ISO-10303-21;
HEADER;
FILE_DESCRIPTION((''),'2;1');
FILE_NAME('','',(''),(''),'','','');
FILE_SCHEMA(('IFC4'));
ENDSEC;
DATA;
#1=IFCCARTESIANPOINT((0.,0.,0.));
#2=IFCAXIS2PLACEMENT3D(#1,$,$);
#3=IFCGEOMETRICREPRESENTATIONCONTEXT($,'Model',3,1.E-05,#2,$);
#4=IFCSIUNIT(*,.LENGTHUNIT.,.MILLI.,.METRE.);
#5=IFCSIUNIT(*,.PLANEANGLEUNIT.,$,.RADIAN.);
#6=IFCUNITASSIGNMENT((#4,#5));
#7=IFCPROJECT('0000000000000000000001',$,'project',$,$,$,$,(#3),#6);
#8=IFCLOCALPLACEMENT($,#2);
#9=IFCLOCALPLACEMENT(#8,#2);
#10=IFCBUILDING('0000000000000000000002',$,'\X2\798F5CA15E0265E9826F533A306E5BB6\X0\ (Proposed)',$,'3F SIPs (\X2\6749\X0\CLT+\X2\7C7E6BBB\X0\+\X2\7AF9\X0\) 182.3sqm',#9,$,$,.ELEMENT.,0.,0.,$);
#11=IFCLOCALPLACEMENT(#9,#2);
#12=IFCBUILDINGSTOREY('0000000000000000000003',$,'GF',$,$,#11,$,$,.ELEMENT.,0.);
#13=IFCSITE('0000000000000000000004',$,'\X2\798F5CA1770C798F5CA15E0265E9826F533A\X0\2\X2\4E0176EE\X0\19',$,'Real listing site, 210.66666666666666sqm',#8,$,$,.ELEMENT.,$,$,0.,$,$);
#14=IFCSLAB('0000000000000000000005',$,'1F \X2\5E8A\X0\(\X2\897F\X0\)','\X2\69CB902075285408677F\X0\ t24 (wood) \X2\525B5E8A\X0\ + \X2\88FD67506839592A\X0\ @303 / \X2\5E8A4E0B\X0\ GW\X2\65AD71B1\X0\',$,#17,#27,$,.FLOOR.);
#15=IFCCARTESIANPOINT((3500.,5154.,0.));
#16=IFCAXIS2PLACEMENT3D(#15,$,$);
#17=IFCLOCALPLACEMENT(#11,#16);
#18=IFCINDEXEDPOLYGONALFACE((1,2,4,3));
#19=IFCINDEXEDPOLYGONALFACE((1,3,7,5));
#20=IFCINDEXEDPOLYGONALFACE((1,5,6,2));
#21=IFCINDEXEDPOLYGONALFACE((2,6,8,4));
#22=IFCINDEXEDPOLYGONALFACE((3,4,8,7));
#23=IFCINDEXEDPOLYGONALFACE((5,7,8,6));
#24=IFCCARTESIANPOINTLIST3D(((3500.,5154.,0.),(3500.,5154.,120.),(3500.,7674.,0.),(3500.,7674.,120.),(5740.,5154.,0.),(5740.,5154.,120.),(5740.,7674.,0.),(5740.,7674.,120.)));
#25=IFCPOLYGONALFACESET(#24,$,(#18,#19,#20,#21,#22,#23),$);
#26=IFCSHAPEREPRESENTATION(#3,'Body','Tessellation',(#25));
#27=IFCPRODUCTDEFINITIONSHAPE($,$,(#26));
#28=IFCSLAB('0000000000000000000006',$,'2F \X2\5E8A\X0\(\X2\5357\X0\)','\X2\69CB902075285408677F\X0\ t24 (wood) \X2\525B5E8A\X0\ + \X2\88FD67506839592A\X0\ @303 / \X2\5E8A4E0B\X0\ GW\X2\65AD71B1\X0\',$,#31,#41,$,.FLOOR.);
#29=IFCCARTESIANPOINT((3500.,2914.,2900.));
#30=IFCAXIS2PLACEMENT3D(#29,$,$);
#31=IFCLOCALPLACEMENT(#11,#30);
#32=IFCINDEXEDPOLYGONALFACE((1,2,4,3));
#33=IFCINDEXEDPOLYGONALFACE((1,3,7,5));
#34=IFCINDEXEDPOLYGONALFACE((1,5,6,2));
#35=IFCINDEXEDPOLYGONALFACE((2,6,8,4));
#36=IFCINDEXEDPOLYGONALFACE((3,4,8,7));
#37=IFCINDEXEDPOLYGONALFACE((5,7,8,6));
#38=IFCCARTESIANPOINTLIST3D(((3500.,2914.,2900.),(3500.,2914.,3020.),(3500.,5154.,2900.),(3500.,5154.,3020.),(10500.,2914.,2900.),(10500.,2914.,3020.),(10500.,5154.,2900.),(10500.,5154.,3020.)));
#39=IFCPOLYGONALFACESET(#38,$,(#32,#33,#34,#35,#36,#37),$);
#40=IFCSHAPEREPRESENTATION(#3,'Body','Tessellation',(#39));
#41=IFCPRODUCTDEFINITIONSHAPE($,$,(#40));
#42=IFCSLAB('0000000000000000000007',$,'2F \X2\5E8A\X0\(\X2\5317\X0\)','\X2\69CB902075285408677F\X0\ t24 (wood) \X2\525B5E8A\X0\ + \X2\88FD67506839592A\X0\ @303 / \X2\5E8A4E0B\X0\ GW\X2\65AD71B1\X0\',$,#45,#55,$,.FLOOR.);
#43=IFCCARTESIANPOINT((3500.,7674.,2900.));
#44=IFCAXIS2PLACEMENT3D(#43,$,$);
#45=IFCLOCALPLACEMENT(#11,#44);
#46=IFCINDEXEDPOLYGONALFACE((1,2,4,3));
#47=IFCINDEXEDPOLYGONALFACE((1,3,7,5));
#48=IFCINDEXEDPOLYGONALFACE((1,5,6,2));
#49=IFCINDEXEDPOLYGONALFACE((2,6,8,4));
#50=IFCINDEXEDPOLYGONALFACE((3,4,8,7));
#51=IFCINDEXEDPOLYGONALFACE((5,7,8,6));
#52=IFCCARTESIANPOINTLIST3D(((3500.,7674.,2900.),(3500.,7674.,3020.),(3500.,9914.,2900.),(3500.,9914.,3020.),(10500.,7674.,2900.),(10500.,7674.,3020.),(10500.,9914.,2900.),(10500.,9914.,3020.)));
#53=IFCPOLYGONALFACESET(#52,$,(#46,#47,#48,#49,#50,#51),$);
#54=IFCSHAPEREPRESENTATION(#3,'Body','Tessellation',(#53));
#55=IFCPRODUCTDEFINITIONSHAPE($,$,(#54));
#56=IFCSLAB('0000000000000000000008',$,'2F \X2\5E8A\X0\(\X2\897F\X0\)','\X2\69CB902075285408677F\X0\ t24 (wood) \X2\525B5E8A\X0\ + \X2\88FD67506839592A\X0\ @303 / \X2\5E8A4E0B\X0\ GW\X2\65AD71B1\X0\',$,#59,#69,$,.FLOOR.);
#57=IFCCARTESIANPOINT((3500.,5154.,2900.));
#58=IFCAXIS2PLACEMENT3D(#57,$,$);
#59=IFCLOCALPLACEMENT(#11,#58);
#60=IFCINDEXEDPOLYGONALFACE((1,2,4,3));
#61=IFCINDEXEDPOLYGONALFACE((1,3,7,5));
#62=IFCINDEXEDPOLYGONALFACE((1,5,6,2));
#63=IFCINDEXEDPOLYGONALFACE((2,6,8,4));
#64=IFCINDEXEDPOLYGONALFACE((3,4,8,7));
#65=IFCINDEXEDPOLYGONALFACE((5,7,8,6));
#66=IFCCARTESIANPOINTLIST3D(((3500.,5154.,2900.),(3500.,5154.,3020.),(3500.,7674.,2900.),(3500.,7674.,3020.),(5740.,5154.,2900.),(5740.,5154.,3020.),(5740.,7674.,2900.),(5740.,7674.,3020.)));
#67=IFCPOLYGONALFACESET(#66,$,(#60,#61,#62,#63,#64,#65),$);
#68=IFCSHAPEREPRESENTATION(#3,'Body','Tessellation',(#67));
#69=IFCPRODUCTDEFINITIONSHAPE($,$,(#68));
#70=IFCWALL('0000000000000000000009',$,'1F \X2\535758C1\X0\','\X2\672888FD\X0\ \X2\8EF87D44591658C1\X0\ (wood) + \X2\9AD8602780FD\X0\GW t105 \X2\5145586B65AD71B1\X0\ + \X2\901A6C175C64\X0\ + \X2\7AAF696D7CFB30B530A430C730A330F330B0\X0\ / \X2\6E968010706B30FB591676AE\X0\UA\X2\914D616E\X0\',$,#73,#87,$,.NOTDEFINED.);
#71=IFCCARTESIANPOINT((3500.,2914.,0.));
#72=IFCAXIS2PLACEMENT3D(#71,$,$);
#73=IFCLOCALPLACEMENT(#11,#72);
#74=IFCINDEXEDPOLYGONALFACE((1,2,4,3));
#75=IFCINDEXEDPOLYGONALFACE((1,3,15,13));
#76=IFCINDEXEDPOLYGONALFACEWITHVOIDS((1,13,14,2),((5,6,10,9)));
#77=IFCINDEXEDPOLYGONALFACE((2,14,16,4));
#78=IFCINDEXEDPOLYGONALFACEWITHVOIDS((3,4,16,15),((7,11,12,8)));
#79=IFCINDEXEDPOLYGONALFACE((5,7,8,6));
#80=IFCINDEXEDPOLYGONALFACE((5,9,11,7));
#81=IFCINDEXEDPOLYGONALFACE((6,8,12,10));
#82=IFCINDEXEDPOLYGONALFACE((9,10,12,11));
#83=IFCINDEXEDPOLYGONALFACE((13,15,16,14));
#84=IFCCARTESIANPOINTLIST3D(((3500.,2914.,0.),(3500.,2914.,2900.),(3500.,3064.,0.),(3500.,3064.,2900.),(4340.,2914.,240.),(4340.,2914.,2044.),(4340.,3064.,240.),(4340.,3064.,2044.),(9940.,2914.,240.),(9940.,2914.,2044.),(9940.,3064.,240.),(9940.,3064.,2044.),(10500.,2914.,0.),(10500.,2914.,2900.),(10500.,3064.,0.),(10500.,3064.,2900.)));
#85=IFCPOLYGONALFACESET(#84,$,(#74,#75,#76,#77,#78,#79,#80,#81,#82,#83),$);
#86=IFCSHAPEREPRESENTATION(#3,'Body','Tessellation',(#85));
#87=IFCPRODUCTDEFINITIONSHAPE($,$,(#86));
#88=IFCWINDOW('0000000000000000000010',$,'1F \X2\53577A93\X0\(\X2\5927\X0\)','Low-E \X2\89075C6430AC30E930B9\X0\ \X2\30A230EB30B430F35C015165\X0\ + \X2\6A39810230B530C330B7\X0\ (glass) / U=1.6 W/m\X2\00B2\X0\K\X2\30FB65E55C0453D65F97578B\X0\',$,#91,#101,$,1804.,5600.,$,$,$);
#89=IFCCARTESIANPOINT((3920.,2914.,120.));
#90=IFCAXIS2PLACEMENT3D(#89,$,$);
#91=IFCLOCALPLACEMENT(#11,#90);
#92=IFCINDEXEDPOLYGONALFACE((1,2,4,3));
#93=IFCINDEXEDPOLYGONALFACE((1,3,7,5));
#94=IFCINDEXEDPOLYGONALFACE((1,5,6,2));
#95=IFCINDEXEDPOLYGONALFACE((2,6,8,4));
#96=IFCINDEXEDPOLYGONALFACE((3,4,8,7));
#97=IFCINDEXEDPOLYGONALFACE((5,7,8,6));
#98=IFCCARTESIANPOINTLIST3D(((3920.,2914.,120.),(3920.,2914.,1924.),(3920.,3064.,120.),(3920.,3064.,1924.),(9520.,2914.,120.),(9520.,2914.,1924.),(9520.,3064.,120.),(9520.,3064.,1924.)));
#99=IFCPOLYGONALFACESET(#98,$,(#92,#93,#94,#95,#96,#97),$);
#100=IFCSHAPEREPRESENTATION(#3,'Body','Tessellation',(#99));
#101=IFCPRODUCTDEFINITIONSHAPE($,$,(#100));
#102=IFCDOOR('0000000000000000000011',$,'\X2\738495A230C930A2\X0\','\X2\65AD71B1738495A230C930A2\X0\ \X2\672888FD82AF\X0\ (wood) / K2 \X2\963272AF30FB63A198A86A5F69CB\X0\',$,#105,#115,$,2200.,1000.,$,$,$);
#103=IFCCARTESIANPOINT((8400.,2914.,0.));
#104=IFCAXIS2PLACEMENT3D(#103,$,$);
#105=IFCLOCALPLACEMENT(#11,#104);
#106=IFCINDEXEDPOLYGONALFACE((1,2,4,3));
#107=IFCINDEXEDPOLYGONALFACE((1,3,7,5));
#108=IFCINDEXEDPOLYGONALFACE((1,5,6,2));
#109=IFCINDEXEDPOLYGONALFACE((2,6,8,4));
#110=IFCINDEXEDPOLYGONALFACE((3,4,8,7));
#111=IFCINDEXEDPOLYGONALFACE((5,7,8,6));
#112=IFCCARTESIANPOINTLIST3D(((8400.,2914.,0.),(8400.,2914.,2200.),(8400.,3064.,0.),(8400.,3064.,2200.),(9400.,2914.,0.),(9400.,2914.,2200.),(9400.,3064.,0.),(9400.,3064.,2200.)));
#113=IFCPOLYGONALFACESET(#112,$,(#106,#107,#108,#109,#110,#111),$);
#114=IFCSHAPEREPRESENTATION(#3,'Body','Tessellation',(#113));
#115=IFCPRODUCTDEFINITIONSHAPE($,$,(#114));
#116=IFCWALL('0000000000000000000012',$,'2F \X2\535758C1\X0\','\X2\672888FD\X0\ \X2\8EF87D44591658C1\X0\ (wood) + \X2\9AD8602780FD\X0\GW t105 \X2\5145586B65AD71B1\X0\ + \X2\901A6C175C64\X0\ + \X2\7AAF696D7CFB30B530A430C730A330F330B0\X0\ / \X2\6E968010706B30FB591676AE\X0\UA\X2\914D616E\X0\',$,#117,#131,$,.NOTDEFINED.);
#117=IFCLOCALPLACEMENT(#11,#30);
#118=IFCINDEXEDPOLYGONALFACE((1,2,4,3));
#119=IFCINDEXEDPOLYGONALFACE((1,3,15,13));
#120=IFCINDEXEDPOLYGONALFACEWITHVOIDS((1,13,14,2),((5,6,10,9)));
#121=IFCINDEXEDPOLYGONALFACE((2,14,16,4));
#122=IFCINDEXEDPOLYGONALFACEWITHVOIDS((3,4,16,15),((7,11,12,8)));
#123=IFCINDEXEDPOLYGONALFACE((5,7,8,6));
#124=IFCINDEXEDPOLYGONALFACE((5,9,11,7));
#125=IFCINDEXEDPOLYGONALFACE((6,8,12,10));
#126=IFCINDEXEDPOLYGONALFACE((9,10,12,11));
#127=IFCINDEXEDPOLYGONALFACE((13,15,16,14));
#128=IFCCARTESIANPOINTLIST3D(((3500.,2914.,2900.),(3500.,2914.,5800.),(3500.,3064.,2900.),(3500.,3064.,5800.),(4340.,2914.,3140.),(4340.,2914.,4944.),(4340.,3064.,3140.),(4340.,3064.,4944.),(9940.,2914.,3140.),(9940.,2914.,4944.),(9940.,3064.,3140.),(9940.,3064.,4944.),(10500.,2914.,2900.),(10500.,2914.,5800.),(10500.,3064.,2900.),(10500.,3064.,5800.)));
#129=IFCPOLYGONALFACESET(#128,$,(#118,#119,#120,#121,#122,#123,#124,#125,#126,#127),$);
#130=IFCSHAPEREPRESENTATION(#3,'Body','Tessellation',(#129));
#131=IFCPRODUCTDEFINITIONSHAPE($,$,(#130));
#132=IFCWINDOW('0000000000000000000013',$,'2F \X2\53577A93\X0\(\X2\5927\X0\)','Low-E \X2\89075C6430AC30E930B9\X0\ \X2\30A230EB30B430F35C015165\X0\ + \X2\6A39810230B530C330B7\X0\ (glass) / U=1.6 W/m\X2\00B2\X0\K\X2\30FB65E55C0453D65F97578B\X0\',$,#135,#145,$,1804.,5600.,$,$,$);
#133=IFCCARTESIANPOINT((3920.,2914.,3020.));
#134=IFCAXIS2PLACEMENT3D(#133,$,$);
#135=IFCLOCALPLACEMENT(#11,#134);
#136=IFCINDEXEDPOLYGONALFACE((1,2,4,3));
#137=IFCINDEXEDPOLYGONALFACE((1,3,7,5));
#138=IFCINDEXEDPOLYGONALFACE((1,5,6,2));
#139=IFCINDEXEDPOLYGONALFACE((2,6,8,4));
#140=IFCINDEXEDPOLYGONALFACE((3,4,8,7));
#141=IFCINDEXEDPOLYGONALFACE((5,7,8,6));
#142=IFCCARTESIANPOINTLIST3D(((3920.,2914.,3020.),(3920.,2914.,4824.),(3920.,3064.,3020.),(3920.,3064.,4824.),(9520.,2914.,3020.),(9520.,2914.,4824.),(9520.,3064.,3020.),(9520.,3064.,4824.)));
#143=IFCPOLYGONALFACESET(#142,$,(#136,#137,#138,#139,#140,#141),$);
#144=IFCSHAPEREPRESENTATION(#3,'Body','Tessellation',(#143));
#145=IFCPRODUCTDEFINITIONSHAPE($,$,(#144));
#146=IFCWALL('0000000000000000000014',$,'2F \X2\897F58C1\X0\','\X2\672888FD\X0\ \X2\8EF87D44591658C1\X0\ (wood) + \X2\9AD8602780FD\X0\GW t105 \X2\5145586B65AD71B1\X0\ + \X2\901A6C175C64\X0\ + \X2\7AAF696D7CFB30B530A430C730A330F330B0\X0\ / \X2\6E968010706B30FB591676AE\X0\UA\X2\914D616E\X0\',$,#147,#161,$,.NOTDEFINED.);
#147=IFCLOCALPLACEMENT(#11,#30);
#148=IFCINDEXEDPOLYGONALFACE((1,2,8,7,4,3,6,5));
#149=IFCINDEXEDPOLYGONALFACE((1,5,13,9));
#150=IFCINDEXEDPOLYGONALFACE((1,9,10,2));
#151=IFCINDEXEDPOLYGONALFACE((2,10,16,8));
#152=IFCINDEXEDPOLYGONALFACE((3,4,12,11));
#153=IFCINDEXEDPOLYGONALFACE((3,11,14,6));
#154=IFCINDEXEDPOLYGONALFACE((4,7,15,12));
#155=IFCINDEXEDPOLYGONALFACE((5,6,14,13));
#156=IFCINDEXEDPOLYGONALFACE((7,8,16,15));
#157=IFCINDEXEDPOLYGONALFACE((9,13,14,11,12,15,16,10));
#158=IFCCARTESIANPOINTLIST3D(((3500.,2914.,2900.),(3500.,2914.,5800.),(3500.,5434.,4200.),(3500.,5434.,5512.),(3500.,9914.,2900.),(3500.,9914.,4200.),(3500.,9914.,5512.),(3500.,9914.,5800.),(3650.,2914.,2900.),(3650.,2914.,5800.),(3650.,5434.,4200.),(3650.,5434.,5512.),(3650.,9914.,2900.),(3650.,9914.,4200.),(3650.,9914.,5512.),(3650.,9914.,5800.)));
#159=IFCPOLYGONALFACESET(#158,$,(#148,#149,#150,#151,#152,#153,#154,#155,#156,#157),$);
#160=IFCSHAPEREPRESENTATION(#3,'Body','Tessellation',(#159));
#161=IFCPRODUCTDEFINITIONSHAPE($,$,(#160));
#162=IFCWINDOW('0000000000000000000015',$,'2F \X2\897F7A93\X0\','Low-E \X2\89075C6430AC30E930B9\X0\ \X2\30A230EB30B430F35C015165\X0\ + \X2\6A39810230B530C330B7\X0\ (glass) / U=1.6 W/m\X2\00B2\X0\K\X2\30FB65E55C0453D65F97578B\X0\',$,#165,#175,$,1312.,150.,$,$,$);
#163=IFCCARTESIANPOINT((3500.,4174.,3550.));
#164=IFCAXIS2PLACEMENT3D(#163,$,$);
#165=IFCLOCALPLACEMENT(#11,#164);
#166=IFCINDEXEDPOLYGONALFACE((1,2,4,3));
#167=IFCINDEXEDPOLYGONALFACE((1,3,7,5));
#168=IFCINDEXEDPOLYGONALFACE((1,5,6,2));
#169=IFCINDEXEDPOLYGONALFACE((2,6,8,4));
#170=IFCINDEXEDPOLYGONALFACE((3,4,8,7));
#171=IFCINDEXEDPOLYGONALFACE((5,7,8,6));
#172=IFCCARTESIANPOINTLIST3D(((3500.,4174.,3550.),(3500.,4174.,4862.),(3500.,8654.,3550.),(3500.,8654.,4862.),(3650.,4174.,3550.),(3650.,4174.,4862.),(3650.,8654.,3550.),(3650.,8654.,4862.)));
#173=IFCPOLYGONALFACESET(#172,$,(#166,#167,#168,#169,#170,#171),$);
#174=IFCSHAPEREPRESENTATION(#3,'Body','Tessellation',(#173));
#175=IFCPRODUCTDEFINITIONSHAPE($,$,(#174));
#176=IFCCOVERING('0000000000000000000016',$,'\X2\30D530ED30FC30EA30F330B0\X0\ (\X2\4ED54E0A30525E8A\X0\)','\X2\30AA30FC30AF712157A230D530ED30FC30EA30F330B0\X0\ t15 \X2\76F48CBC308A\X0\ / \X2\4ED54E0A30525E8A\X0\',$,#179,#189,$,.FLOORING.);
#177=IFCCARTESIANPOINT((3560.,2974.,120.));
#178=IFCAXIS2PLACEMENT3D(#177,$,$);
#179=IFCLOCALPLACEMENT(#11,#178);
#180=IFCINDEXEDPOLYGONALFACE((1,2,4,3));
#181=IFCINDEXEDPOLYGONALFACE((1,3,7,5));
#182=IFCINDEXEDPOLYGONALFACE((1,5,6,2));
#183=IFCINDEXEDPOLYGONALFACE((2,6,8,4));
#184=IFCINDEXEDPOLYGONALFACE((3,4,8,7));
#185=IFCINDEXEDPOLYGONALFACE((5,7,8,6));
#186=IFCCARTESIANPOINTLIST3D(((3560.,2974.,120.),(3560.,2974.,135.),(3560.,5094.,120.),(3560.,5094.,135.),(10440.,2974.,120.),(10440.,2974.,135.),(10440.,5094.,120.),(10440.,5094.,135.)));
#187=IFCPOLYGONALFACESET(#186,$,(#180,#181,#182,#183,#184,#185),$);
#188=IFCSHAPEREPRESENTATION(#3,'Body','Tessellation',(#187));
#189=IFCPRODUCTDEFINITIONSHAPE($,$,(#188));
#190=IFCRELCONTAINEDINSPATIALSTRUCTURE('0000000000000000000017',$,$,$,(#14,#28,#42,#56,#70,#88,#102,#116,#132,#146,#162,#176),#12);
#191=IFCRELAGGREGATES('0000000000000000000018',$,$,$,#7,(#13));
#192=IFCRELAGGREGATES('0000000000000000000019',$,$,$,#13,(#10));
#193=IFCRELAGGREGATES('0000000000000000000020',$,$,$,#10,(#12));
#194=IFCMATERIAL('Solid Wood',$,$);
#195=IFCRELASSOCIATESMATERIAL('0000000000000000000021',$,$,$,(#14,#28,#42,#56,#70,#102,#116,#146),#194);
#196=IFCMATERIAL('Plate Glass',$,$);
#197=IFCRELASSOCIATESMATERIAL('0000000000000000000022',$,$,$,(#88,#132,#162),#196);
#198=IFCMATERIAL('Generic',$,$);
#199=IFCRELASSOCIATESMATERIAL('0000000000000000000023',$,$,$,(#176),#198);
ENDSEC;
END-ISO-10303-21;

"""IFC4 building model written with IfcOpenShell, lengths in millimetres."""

from ifc_helpers import new_model, si_unit, frame, frame_2d, origin, place, context, project, spatial, rectangle, extrude, material, element, fill, save


model = new_model("IFC4")

# Units and contexts
model_context = context("Model", 3, precision=1e-05, world=origin())
ifc_project = project(units=[si_unit("LENGTHUNIT", "METRE", prefix="MILLI"), si_unit("PLANEANGLEUNIT", "RADIAN")], contexts=[model_context])

# Site, building, storey
site_placement = place(None, origin())
site = spatial("IfcSite", under=ifc_project, at=site_placement, Name="福岡県福岡市早良区2丁目19", ObjectType="Real listing site, 210.66666666666666sqm", CompositionType="ELEMENT", RefElevation=0.0)
building_placement = place(site_placement, origin())
building = spatial("IfcBuilding", under=site, at=building_placement, Name="福岡市早良区の家 (Proposed)", ObjectType="3F SIPs (杉CLT+籾殻+竹) 182.3sqm", CompositionType="ELEMENT", ElevationOfRefHeight=0.0, ElevationOfTerrain=0.0)
storey_placement = place(building_placement, origin())
storey = spatial("IfcBuildingStorey", under=building, at=storey_placement, Name="GF", CompositionType="ELEMENT", Elevation=0.0)

# Slabs
ifc_material_1 = material(Name="Solid Wood")
slab_1_placement = place(storey_placement, frame((3500.0, 5154.0, 0.0)))
element("IfcSlab", 1, at=slab_1_placement, inside=storey, material=ifc_material_1, Name="1F 床(西)", Description="構造用合板 t24 (wood) 剛床 + 製材根太 @303 / 床下 GW断熱", PredefinedType="FLOOR", context=model_context, shape_type="SweptSolid", body=[
    extrude(rectangle(XDim=2240.0, YDim=2520.0, at=frame_2d((1120.0, 1260.0))), frame((3500.0, 5154.0, 0.0)), (0.0, 0.0, 1.0), 120.0),
])
slab_2_placement = place(storey_placement, frame((3500.0, 2914.0, 2900.0)))
element("IfcSlab", 2, at=slab_2_placement, inside=storey, material=ifc_material_1, Name="2F 床(南)", Description="構造用合板 t24 (wood) 剛床 + 製材根太 @303 / 床下 GW断熱", PredefinedType="FLOOR", context=model_context, shape_type="SweptSolid", body=[
    extrude(rectangle(XDim=7000.0, YDim=2240.0, at=frame_2d((3500.0, 1120.0))), frame((3500.0, 2914.0, 2900.0)), (0.0, 0.0, 1.0), 120.0),
])
slab_3_placement = place(storey_placement, frame((3500.0, 7674.0, 2900.0)))
element("IfcSlab", 3, at=slab_3_placement, inside=storey, material=ifc_material_1, Name="2F 床(北)", Description="構造用合板 t24 (wood) 剛床 + 製材根太 @303 / 床下 GW断熱", PredefinedType="FLOOR", context=model_context, shape_type="SweptSolid", body=[
    extrude(rectangle(XDim=7000.0, YDim=2240.0, at=frame_2d((3500.0, 1120.0))), frame((3500.0, 7674.0, 2900.0)), (0.0, 0.0, 1.0), 120.0),
])
slab_4_placement = place(storey_placement, frame((3500.0, 5154.0, 2900.0)))
element("IfcSlab", 4, at=slab_4_placement, inside=storey, material=ifc_material_1, Name="2F 床(西)", Description="構造用合板 t24 (wood) 剛床 + 製材根太 @303 / 床下 GW断熱", PredefinedType="FLOOR", context=model_context, shape_type="SweptSolid", body=[
    extrude(rectangle(XDim=2240.0, YDim=2520.0, at=frame_2d((1120.0, 1260.0))), frame((3500.0, 5154.0, 2900.0)), (0.0, 0.0, 1.0), 120.0),
])

# Wall, openings, window, door
wall_1_placement = place(storey_placement, frame((3500.0, 2914.0, 0.0)))
wall_1 = element("IfcWall", 5, at=wall_1_placement, inside=storey, material=ifc_material_1, Name="1F 南壁", Description="木製 軸組外壁 (wood) + 高性能GW t105 充填断熱 + 通気層 + 窯業系サイディング / 準耐火・外皮UA配慮", PredefinedType="NOTDEFINED", context=model_context, shape_type="SweptSolid", body=[
    extrude(rectangle(XDim=7000.0, YDim=150.0, at=frame_2d((3500.0, 75.0))), frame((3500.0, 2914.0, 0.0)), (0.0, 0.0, 1.0), 2900.0),
])
opening_1_placement = place(storey_placement, frame((3920.0, 2914.0, 120.0)))
opening_1 = element("IfcOpeningElement", 6, at=opening_1_placement, cuts=wall_1, PredefinedType="NOTDEFINED", context=model_context, shape_type="SweptSolid", body=[
    extrude(rectangle(XDim=5600.0, YDim=150.0, at=frame_2d((2800.0, 75.0))), frame((3920.0, 2914.0, 120.0)), (0.0, 0.0, 1.0), 1804.0),
])
opening_2_placement = place(storey_placement, frame((8400.0, 2914.0, 0.0)))
opening_2 = element("IfcOpeningElement", 7, at=opening_2_placement, cuts=wall_1, PredefinedType="NOTDEFINED", context=model_context, shape_type="SweptSolid", body=[
    extrude(rectangle(XDim=1000.0, YDim=150.0, at=frame_2d((500.0, 75.0))), frame((8400.0, 2914.0, 0.0)), (0.0, 0.0, 1.0), 2200.0),
])
ifc_material_2 = material(Name="Plate Glass")
window_1_placement = place(storey_placement, frame((3920.0, 2914.0, 120.0)))
window_1 = element("IfcWindow", 8, at=window_1_placement, inside=storey, material=ifc_material_2, Name="1F 南窓(大)", Description="Low-E 複層ガラス アルゴン封入 + 樹脂サッシ (glass) / U=1.6 W/m²K・日射取得型", OverallHeight=1804.0, OverallWidth=5600.0, context=model_context, shape_type="SweptSolid", body=[
    extrude(rectangle(XDim=5600.0, YDim=150.0, at=frame_2d((2800.0, 75.0))), frame((3920.0, 2914.0, 120.0)), (0.0, 0.0, 1.0), 1804.0),
])
fill(opening_1, window_1)
door_placement = place(storey_placement, frame((8400.0, 2914.0, 0.0)))
door = element("IfcDoor", 9, at=door_placement, inside=storey, material=ifc_material_1, Name="玄関ドア", Description="断熱玄関ドア 木製芯 (wood) / K2 防犯・採風機構", OverallHeight=2200.0, OverallWidth=1000.0, context=model_context, shape_type="SweptSolid", body=[
    extrude(rectangle(XDim=1000.0, YDim=150.0, at=frame_2d((500.0, 75.0))), frame((8400.0, 2914.0, 0.0)), (0.0, 0.0, 1.0), 2200.0),
])
fill(opening_2, door)

# Wall, opening, window
wall_2_placement = place(storey_placement, frame((3500.0, 2914.0, 2900.0)))
wall_2 = element("IfcWall", 10, at=wall_2_placement, inside=storey, material=ifc_material_1, Name="2F 南壁", Description="木製 軸組外壁 (wood) + 高性能GW t105 充填断熱 + 通気層 + 窯業系サイディング / 準耐火・外皮UA配慮", PredefinedType="NOTDEFINED", context=model_context, shape_type="SweptSolid", body=[
    extrude(rectangle(XDim=7000.0, YDim=150.0, at=frame_2d((3500.0, 75.0))), frame((3500.0, 2914.0, 2900.0)), (0.0, 0.0, 1.0), 2900.0),
])
opening_3_placement = place(storey_placement, frame((3920.0, 2914.0, 3020.0)))
opening_3 = element("IfcOpeningElement", 11, at=opening_3_placement, cuts=wall_2, PredefinedType="NOTDEFINED", context=model_context, shape_type="SweptSolid", body=[
    extrude(rectangle(XDim=5600.0, YDim=150.0, at=frame_2d((2800.0, 75.0))), frame((3920.0, 2914.0, 3020.0)), (0.0, 0.0, 1.0), 1804.0),
])
window_2_placement = place(storey_placement, frame((3920.0, 2914.0, 3020.0)))
window_2 = element("IfcWindow", 12, at=window_2_placement, inside=storey, material=ifc_material_2, Name="2F 南窓(大)", Description="Low-E 複層ガラス アルゴン封入 + 樹脂サッシ (glass) / U=1.6 W/m²K・日射取得型", OverallHeight=1804.0, OverallWidth=5600.0, context=model_context, shape_type="SweptSolid", body=[
    extrude(rectangle(XDim=5600.0, YDim=150.0, at=frame_2d((2800.0, 75.0))), frame((3920.0, 2914.0, 3020.0)), (0.0, 0.0, 1.0), 1804.0),
])
fill(opening_3, window_2)

# Wall, opening, window
wall_3_placement = place(storey_placement, frame((3500.0, 2914.0, 2900.0)))
wall_3 = element("IfcWall", 13, at=wall_3_placement, inside=storey, material=ifc_material_1, Name="2F 西壁", Description="木製 軸組外壁 (wood) + 高性能GW t105 充填断熱 + 通気層 + 窯業系サイディング / 準耐火・外皮UA配慮", PredefinedType="NOTDEFINED", context=model_context, shape_type="SweptSolid", body=[
    extrude(rectangle(XDim=150.0, YDim=7000.0, at=frame_2d((75.0, 3500.0))), frame((3500.0, 2914.0, 2900.0)), (0.0, 0.0, 1.0), 2900.0),
])
opening_4_placement = place(storey_placement, frame((3500.0, 4174.0, 3550.0)))
opening_4 = element("IfcOpeningElement", 14, at=opening_4_placement, cuts=wall_3, PredefinedType="NOTDEFINED", context=model_context, shape_type="SweptSolid", body=[
    extrude(rectangle(XDim=150.0, YDim=4480.0, at=frame_2d((75.0, 2240.0))), frame((3500.0, 4174.0, 3550.0)), (0.0, 0.0, 1.0), 1312.0),
])
window_3_placement = place(storey_placement, frame((3500.0, 4174.0, 3550.0)))
window_3 = element("IfcWindow", 15, at=window_3_placement, inside=storey, material=ifc_material_2, Name="2F 西窓", Description="Low-E 複層ガラス アルゴン封入 + 樹脂サッシ (glass) / U=1.6 W/m²K・日射取得型", OverallHeight=1312.0, OverallWidth=150.0, context=model_context, shape_type="SweptSolid", body=[
    extrude(rectangle(XDim=150.0, YDim=4480.0, at=frame_2d((75.0, 2240.0))), frame((3500.0, 4174.0, 3550.0)), (0.0, 0.0, 1.0), 1312.0),
])
fill(opening_4, window_3)

# Covering
ifc_material_3 = material(Name="Generic")
covering_1_placement = place(storey_placement, frame((3560.0, 2974.0, 120.0)))
element("IfcCovering", 16, at=covering_1_placement, inside=storey, material=ifc_material_3, Name="フローリング (仕上げ床)", Description="オーク無垢フローリング t15 直貼り / 仕上げ床", PredefinedType="FLOORING", context=model_context, shape_type="SweptSolid", body=[
    extrude(rectangle(XDim=6880.0, YDim=2120.0, at=frame_2d((3440.0, 1060.0))), frame((3560.0, 2974.0, 120.0)), (0.0, 0.0, 1.0), 15.0),
])

save(model, "model.ifc")
